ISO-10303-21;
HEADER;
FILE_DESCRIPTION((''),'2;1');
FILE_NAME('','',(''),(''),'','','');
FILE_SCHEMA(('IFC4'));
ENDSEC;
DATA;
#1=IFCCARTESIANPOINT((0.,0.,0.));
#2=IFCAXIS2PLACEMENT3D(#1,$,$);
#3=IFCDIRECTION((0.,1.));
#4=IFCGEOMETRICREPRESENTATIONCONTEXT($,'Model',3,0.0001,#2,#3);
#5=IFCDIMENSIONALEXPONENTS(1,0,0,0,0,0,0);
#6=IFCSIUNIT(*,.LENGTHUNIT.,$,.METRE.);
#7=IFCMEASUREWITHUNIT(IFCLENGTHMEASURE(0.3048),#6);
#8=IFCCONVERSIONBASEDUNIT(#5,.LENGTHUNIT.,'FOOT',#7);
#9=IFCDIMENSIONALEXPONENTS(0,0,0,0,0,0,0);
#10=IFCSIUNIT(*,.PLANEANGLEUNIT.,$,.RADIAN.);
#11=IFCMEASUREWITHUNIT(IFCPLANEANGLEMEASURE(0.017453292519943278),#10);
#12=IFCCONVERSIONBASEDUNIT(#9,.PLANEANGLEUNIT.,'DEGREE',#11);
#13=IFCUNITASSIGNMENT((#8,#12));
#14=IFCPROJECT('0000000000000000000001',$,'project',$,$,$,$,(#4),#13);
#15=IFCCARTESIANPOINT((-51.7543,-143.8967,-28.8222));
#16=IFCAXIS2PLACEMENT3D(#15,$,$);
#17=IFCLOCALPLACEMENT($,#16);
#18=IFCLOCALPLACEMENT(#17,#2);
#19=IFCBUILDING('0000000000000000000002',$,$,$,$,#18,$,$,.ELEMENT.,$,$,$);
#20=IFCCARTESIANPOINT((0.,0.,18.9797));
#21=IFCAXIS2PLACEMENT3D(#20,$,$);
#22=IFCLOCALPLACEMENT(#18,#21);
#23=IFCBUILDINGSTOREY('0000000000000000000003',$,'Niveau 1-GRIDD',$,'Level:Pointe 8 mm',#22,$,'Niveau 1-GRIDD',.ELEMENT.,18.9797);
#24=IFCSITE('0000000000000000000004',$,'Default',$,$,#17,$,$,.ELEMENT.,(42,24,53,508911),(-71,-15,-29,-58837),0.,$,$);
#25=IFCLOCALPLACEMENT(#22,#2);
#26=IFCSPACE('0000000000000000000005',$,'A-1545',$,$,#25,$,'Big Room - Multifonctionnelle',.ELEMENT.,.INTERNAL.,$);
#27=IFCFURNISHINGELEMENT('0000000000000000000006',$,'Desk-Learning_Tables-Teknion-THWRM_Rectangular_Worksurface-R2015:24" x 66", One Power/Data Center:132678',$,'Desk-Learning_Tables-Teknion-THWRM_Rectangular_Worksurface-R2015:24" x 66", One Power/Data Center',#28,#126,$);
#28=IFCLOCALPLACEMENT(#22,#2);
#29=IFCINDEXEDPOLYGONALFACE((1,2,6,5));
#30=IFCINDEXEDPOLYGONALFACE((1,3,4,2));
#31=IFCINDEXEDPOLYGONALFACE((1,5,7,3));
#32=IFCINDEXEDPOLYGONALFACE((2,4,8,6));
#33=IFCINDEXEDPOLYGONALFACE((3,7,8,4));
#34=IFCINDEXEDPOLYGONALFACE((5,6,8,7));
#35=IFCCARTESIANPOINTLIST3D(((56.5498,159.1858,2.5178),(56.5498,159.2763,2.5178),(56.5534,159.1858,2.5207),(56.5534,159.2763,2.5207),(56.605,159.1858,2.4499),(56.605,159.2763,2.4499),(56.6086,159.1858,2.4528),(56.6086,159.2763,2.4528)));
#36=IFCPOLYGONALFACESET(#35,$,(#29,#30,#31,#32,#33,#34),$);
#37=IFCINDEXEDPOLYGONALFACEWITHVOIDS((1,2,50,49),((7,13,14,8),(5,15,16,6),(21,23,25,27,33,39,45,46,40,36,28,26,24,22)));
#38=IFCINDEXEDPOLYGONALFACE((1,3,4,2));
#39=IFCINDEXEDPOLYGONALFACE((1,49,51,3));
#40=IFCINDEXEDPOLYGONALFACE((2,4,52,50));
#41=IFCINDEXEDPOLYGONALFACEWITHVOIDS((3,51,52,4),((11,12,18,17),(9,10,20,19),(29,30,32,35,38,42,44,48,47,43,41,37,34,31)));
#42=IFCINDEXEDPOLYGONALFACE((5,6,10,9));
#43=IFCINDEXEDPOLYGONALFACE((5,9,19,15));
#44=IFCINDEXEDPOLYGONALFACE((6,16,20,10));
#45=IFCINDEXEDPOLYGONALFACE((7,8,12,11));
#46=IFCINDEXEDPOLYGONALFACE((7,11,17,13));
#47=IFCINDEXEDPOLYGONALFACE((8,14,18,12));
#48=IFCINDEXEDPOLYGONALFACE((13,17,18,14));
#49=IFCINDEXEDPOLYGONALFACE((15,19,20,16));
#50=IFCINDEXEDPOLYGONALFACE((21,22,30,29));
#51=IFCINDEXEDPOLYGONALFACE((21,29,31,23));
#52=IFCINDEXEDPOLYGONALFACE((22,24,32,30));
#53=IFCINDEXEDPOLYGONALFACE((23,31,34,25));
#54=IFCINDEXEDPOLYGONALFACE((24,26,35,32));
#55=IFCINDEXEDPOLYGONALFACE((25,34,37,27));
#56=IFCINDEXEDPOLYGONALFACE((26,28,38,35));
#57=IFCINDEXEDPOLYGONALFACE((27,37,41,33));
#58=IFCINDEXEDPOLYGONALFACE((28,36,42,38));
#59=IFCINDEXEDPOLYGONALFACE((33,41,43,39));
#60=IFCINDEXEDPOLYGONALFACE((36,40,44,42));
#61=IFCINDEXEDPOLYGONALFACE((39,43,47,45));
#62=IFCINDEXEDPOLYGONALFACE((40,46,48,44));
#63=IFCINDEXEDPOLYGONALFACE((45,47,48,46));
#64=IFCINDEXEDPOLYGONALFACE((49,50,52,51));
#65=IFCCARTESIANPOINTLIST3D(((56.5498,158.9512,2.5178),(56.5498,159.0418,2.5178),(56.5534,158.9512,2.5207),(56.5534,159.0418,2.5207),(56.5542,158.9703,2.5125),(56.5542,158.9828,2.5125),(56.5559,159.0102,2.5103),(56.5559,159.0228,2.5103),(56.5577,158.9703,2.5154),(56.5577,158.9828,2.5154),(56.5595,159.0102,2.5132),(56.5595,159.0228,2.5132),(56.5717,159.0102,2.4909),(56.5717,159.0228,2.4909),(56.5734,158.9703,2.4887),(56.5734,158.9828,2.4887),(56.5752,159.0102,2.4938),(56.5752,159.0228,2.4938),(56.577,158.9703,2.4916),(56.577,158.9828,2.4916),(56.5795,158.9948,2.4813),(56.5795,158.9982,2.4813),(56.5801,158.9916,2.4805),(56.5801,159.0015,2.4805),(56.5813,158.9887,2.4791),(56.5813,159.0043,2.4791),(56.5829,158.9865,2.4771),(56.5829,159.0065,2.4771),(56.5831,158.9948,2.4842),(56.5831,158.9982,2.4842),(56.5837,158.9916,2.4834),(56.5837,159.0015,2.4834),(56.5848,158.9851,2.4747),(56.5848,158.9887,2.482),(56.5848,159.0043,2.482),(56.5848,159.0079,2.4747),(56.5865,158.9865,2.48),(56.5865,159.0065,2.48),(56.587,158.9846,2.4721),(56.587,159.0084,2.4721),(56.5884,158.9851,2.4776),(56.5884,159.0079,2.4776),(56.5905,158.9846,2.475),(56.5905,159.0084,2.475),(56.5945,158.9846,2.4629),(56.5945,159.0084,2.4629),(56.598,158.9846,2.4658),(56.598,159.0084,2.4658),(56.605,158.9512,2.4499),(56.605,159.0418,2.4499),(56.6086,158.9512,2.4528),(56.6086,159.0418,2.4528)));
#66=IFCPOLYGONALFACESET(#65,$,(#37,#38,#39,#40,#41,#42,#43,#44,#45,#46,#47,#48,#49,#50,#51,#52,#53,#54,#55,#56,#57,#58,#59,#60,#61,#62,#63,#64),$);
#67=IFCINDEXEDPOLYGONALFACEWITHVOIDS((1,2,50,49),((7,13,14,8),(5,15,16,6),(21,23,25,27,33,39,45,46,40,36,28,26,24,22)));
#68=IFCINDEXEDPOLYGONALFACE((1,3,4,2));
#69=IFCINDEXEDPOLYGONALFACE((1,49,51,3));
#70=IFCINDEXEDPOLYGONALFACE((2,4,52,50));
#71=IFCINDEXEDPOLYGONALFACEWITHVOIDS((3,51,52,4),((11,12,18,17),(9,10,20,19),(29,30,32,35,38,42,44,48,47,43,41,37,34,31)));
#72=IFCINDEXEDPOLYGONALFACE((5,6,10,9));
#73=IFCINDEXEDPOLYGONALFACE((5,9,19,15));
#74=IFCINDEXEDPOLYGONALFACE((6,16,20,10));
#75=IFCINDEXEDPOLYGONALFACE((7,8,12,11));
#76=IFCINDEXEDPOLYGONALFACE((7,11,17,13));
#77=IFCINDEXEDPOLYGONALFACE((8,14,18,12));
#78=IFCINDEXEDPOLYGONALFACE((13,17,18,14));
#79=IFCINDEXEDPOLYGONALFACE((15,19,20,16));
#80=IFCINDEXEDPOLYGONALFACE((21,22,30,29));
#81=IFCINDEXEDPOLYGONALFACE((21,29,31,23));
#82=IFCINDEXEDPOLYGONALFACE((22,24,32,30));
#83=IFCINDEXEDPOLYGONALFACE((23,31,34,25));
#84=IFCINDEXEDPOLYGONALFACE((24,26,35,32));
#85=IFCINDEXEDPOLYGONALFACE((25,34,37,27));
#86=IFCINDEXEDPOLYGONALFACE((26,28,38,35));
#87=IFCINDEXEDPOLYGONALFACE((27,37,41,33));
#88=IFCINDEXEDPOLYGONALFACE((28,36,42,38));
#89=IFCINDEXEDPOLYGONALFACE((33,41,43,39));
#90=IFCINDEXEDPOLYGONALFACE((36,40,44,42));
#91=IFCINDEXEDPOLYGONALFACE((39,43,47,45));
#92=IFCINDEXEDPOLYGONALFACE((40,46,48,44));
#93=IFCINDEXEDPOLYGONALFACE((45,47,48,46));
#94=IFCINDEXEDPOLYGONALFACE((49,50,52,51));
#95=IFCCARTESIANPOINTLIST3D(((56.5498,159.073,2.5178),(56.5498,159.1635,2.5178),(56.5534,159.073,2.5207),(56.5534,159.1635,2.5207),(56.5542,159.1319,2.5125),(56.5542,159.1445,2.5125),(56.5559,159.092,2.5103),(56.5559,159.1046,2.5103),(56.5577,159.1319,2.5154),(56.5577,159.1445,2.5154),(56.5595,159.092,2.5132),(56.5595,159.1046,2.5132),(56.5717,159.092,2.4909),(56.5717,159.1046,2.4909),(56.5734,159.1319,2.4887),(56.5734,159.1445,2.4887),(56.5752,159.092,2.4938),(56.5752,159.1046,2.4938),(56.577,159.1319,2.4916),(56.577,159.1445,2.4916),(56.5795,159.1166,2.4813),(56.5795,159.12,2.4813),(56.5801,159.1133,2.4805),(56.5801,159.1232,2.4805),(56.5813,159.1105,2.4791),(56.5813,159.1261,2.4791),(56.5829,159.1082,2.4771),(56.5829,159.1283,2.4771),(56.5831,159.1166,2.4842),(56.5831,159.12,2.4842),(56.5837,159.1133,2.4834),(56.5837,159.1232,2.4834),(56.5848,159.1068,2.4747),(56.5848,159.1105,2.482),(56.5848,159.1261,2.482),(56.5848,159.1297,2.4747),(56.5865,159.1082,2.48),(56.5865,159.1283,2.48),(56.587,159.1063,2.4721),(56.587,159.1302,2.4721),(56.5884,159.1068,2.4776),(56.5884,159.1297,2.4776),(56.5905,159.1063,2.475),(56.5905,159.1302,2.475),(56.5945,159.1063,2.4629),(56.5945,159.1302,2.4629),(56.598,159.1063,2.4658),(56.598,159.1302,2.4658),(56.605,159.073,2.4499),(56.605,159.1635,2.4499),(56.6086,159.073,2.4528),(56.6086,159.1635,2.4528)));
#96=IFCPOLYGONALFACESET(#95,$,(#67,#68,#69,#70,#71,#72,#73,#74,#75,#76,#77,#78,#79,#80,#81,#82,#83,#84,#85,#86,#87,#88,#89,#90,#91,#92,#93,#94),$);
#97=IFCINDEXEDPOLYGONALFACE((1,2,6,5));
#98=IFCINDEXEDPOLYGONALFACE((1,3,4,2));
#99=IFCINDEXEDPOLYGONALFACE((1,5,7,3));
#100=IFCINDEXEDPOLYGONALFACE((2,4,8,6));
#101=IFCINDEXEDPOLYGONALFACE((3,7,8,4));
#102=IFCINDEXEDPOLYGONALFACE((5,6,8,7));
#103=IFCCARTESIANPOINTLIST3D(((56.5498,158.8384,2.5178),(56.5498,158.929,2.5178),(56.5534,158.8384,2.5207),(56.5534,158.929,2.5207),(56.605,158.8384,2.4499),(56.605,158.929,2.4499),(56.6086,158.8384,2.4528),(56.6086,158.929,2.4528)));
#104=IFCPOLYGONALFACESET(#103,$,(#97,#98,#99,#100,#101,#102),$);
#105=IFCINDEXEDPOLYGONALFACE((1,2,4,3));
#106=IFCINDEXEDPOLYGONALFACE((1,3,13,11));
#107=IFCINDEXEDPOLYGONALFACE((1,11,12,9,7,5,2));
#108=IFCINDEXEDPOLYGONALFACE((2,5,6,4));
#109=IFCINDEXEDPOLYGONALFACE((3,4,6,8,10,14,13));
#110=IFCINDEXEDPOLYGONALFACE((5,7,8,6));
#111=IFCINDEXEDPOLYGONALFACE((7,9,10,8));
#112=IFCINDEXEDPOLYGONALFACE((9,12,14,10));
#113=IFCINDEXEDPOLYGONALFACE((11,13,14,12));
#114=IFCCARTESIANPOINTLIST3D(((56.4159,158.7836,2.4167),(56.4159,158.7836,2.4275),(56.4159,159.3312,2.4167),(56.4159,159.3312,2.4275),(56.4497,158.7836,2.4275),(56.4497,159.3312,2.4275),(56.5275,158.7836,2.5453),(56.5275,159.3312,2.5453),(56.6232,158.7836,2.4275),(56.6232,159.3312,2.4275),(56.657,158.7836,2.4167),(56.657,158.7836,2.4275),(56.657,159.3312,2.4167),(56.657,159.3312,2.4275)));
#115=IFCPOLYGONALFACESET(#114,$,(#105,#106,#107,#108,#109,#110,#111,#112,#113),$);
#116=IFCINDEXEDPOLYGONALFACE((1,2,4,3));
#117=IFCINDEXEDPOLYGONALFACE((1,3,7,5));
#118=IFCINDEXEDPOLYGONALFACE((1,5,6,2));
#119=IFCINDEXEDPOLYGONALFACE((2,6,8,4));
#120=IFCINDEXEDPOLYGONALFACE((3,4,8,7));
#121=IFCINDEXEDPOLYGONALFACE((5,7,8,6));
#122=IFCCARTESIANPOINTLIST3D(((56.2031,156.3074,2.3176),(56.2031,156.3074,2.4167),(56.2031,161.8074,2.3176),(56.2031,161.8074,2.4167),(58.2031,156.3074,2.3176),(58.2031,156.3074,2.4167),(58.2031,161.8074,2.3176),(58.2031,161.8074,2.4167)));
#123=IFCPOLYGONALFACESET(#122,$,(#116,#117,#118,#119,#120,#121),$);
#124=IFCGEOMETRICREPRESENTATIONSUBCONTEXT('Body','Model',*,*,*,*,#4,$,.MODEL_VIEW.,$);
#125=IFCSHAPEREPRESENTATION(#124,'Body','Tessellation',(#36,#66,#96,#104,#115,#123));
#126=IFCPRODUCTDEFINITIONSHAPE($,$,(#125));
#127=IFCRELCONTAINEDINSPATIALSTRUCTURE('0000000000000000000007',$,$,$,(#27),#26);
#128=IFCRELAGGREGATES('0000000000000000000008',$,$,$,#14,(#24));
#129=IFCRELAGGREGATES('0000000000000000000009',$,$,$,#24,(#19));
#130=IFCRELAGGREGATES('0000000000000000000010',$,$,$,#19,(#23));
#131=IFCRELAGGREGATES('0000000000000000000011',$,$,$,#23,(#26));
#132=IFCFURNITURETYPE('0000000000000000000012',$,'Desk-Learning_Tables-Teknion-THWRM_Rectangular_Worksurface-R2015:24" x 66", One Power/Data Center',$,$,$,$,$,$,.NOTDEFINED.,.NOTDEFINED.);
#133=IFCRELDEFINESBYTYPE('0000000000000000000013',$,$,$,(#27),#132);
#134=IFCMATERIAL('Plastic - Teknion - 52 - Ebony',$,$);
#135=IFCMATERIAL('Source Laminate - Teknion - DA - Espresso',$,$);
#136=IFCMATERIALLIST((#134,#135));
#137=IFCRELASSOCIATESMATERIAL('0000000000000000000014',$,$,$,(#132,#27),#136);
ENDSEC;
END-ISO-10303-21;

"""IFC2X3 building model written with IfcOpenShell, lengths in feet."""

from ifc_helpers import new_model, entity, si_unit, converted_unit, direction, frame, frame_2d, origin, place, context, subcontext, project, spatial, polyline, circle_curve, parameter, trimmed, segment, composite_curve, rectangle, outline, extrude, source, transform, mapped, material, material_list, type_object, type_shapes, element, save


model = new_model("IFC2X3")

# Units and contexts
model_context = context("Model", 3, precision=0.0001, world=origin(), true_north=direction((0.0, 1.0)))
body_context = subcontext(model_context, "Body", "Model", "MODEL_VIEW")
ifc_project = project(units=[converted_unit("LENGTHUNIT", "FOOT", entity("IfcLengthMeasure", 0.3048), si_unit("LENGTHUNIT", "METRE"), dimensions=[1, 0, 0, 0, 0, 0, 0]), converted_unit("PLANEANGLEUNIT", "DEGREE", entity("IfcPlaneAngleMeasure", 0.017453292519943278), si_unit("PLANEANGLEUNIT", "RADIAN"), dimensions=[0, 0, 0, 0, 0, 0, 0])], contexts=[model_context])

# Site, building, storey
site_placement = place(None, frame((-51.7543, -143.8967, -28.8222)))
site = spatial("IfcSite", under=ifc_project, at=site_placement, Name="Default", CompositionType="ELEMENT", RefLatitude=(42, 24, 53, 508911), RefLongitude=(-71, -15, -29, -58837), RefElevation=0.0)
building_placement = place(site_placement, origin())
building = spatial("IfcBuilding", under=site, at=building_placement, CompositionType="ELEMENT")
storey_placement = place(building_placement, frame((0.0, 0.0, 18.9797)))
storey = spatial("IfcBuildingStorey", under=building, at=storey_placement, Name="Niveau 1-GRIDD", ObjectType="Level:Pointe 8 mm", LongName="Niveau 1-GRIDD", CompositionType="ELEMENT", Elevation=18.9797)

# Shared definitions
space_placement = place(storey_placement, origin())
space = spatial("IfcSpace", under=storey, at=space_placement, Name="A-1545", LongName="Big Room - Multifonctionnelle", CompositionType="ELEMENT", InteriorOrExteriorSpace="INTERNAL")

# Furnishing element
ifc_material_1 = material(Name="Plastic - Teknion - 52 - Ebony")
ifc_material_2 = material(Name="Source Laminate - Teknion - DA - Espresso")
ifc_material_list_1 = material_list([ifc_material_1, ifc_material_2])
furniture_type_1 = type_object("IfcFurnitureType", Name="Desk-Learning_Tables-Teknion-THWRM_Rectangular_Worksurface-R2015:24\" x 66\", One Power/Data Center", AssemblyPlace="NOTDEFINED", material=ifc_material_list_1)
shared_shape_1 = source(origin(), body_context, "Body", "SweptSolid", [
    extrude(rectangle(XDim=0.0875, YDim=0.0046, at=frame_2d((0.0, 0.0), x_axis=(0.0, 1.0))), frame((0.1284, 0.6239, 2.4853), z_axis=(1.0, 0.0, 0.0), x_axis=(0.0, 0.776046, -0.630676)), (0.0, 0.0, 1.0), 0.0906),
    extrude(outline(polyline([(-0.0453, -0.0438), (0.0453, -0.0438), (0.0453, 0.0438), (-0.0453, 0.0438), (-0.0453, -0.0438)]), holes=[polyline([(-0.0262, -0.0063), (-0.0137, -0.0063), (-0.0137, -0.0369), (-0.0262, -0.0369), (-0.0262, -0.0063)]), polyline([(0.0137, -0.0341), (0.0137, -0.0091), (0.0262, -0.0091), (0.0262, -0.0341), (0.0137, -0.0341)]), composite_curve([segment(polyline([(-0.0119, 0.027), (0.0119, 0.027)]), True, "CONTINUOUS"), segment(polyline([(0.0119, 0.027), (0.0119, 0.0151)]), True, "CONTINUOUS"), segment(trimmed(circle_curve(frame_2d((0.0, 0.0151), x_axis=(0.0, -1.0)), 0.0119), [parameter(270.0)], [parameter(90.0)], True, "PARAMETER"), False, "CONTINUOUS"), segment(polyline([(-0.0119, 0.0151), (-0.0119, 0.027)]), True, "CONTINUOUS")], self_intersect=False)]), frame((-0.0609, 0.6221, 2.4867), z_axis=(0.0, 0.776046, -0.630676), x_axis=(1.0, 0.0, 0.0)), (0.0, 0.0, 1.0), 0.0046),
    extrude(outline(polyline([(-0.0438, -0.0453), (0.0438, -0.0453), (0.0438, 0.0453), (-0.0438, 0.0453), (-0.0438, -0.0453)]), holes=[polyline([(-0.0063, -0.0262), (-0.0369, -0.0262), (-0.0369, -0.0137), (-0.0063, -0.0137), (-0.0063, -0.0262)]), polyline([(-0.0341, 0.0137), (-0.0341, 0.0262), (-0.0091, 0.0262), (-0.0091, 0.0137), (-0.0341, 0.0137)]), composite_curve([segment(polyline([(0.027, -0.0119), (0.0151, -0.0119)]), True, "CONTINUOUS"), segment(trimmed(circle_curve(frame_2d((0.0151, 0.0), x_axis=(-1.0, 0.0)), 0.0119), [parameter(270.0)], [parameter(90.0)], True, "PARAMETER"), False, "CONTINUOUS"), segment(polyline([(0.0151, 0.0119), (0.027, 0.0119)]), True, "CONTINUOUS"), segment(polyline([(0.027, 0.0119), (0.027, -0.0119)]), True, "CONTINUOUS")], self_intersect=False)]), frame((0.0609, 0.6221, 2.4867), z_axis=(0.0, 0.776046, -0.630676), x_axis=(0.0, -0.630676, -0.776046)), (0.0, 0.0, 1.0), 0.0046),
    extrude(rectangle(XDim=0.0875, YDim=0.0046, at=frame_2d((0.0, 0.0), x_axis=(0.0, 1.0))), frame((-0.219, 0.6239, 2.4853), z_axis=(1.0, 0.0, 0.0), x_axis=(0.0, 0.776046, -0.630676)), (0.0, 0.0, 1.0), 0.0906),
    extrude(outline(polyline([(-0.0586, -0.0638), (0.0826, -0.0638), (0.0371, 0.0811), (0.0557, 0.1093), (0.0467, 0.1152), (-0.0862, -0.086), (-0.0772, -0.092), (-0.0586, -0.0638)])), frame((-0.2738, 0.6679, 2.4412), z_axis=(1.0, 0.0, 0.0), x_axis=(0.0, -0.551103, 0.834437)), (0.0, 0.0, 1.0), 0.5475),
    extrude(rectangle(XDim=5.5, YDim=2.0, at=frame_2d((0.0, 0.0), x_axis=(1.0, 0.0))), frame((0.0, 0.0, 2.3176), z_axis=(0.0, 0.0, 1.0), x_axis=(-1.0, 0.0, 0.0)), (0.0, 0.0, 1.0), 0.0991),
])
type_shapes(furniture_type_1, [shared_shape_1])
for number, where, z_axis, x_axis, name in (
    (1, (57.2031, 159.0574, 0.0), (0.0, 0.0, 1.0), (0.0, 1.0, 0.0), "Desk-Learning_Tables-Teknion-THWRM_Rectangular_Worksurface-R2015:24\" x 66\", One Power/Data Center:132678"),
):
    element("IfcFurnishingElement", number, at=place(space_placement, frame(where, z_axis=z_axis, x_axis=x_axis)), inside=space, type_object=furniture_type_1, material=ifc_material_list_1, Name=name, ObjectType="Desk-Learning_Tables-Teknion-THWRM_Rectangular_Worksurface-R2015:24\" x 66\", One Power/Data Center", context=body_context, shape_type="MappedRepresentation", body=[
        mapped(shared_shape_1, transform((0.0, 0.0, 0.0), scale=1.0)),
    ])

save(model, "model.ifc")
